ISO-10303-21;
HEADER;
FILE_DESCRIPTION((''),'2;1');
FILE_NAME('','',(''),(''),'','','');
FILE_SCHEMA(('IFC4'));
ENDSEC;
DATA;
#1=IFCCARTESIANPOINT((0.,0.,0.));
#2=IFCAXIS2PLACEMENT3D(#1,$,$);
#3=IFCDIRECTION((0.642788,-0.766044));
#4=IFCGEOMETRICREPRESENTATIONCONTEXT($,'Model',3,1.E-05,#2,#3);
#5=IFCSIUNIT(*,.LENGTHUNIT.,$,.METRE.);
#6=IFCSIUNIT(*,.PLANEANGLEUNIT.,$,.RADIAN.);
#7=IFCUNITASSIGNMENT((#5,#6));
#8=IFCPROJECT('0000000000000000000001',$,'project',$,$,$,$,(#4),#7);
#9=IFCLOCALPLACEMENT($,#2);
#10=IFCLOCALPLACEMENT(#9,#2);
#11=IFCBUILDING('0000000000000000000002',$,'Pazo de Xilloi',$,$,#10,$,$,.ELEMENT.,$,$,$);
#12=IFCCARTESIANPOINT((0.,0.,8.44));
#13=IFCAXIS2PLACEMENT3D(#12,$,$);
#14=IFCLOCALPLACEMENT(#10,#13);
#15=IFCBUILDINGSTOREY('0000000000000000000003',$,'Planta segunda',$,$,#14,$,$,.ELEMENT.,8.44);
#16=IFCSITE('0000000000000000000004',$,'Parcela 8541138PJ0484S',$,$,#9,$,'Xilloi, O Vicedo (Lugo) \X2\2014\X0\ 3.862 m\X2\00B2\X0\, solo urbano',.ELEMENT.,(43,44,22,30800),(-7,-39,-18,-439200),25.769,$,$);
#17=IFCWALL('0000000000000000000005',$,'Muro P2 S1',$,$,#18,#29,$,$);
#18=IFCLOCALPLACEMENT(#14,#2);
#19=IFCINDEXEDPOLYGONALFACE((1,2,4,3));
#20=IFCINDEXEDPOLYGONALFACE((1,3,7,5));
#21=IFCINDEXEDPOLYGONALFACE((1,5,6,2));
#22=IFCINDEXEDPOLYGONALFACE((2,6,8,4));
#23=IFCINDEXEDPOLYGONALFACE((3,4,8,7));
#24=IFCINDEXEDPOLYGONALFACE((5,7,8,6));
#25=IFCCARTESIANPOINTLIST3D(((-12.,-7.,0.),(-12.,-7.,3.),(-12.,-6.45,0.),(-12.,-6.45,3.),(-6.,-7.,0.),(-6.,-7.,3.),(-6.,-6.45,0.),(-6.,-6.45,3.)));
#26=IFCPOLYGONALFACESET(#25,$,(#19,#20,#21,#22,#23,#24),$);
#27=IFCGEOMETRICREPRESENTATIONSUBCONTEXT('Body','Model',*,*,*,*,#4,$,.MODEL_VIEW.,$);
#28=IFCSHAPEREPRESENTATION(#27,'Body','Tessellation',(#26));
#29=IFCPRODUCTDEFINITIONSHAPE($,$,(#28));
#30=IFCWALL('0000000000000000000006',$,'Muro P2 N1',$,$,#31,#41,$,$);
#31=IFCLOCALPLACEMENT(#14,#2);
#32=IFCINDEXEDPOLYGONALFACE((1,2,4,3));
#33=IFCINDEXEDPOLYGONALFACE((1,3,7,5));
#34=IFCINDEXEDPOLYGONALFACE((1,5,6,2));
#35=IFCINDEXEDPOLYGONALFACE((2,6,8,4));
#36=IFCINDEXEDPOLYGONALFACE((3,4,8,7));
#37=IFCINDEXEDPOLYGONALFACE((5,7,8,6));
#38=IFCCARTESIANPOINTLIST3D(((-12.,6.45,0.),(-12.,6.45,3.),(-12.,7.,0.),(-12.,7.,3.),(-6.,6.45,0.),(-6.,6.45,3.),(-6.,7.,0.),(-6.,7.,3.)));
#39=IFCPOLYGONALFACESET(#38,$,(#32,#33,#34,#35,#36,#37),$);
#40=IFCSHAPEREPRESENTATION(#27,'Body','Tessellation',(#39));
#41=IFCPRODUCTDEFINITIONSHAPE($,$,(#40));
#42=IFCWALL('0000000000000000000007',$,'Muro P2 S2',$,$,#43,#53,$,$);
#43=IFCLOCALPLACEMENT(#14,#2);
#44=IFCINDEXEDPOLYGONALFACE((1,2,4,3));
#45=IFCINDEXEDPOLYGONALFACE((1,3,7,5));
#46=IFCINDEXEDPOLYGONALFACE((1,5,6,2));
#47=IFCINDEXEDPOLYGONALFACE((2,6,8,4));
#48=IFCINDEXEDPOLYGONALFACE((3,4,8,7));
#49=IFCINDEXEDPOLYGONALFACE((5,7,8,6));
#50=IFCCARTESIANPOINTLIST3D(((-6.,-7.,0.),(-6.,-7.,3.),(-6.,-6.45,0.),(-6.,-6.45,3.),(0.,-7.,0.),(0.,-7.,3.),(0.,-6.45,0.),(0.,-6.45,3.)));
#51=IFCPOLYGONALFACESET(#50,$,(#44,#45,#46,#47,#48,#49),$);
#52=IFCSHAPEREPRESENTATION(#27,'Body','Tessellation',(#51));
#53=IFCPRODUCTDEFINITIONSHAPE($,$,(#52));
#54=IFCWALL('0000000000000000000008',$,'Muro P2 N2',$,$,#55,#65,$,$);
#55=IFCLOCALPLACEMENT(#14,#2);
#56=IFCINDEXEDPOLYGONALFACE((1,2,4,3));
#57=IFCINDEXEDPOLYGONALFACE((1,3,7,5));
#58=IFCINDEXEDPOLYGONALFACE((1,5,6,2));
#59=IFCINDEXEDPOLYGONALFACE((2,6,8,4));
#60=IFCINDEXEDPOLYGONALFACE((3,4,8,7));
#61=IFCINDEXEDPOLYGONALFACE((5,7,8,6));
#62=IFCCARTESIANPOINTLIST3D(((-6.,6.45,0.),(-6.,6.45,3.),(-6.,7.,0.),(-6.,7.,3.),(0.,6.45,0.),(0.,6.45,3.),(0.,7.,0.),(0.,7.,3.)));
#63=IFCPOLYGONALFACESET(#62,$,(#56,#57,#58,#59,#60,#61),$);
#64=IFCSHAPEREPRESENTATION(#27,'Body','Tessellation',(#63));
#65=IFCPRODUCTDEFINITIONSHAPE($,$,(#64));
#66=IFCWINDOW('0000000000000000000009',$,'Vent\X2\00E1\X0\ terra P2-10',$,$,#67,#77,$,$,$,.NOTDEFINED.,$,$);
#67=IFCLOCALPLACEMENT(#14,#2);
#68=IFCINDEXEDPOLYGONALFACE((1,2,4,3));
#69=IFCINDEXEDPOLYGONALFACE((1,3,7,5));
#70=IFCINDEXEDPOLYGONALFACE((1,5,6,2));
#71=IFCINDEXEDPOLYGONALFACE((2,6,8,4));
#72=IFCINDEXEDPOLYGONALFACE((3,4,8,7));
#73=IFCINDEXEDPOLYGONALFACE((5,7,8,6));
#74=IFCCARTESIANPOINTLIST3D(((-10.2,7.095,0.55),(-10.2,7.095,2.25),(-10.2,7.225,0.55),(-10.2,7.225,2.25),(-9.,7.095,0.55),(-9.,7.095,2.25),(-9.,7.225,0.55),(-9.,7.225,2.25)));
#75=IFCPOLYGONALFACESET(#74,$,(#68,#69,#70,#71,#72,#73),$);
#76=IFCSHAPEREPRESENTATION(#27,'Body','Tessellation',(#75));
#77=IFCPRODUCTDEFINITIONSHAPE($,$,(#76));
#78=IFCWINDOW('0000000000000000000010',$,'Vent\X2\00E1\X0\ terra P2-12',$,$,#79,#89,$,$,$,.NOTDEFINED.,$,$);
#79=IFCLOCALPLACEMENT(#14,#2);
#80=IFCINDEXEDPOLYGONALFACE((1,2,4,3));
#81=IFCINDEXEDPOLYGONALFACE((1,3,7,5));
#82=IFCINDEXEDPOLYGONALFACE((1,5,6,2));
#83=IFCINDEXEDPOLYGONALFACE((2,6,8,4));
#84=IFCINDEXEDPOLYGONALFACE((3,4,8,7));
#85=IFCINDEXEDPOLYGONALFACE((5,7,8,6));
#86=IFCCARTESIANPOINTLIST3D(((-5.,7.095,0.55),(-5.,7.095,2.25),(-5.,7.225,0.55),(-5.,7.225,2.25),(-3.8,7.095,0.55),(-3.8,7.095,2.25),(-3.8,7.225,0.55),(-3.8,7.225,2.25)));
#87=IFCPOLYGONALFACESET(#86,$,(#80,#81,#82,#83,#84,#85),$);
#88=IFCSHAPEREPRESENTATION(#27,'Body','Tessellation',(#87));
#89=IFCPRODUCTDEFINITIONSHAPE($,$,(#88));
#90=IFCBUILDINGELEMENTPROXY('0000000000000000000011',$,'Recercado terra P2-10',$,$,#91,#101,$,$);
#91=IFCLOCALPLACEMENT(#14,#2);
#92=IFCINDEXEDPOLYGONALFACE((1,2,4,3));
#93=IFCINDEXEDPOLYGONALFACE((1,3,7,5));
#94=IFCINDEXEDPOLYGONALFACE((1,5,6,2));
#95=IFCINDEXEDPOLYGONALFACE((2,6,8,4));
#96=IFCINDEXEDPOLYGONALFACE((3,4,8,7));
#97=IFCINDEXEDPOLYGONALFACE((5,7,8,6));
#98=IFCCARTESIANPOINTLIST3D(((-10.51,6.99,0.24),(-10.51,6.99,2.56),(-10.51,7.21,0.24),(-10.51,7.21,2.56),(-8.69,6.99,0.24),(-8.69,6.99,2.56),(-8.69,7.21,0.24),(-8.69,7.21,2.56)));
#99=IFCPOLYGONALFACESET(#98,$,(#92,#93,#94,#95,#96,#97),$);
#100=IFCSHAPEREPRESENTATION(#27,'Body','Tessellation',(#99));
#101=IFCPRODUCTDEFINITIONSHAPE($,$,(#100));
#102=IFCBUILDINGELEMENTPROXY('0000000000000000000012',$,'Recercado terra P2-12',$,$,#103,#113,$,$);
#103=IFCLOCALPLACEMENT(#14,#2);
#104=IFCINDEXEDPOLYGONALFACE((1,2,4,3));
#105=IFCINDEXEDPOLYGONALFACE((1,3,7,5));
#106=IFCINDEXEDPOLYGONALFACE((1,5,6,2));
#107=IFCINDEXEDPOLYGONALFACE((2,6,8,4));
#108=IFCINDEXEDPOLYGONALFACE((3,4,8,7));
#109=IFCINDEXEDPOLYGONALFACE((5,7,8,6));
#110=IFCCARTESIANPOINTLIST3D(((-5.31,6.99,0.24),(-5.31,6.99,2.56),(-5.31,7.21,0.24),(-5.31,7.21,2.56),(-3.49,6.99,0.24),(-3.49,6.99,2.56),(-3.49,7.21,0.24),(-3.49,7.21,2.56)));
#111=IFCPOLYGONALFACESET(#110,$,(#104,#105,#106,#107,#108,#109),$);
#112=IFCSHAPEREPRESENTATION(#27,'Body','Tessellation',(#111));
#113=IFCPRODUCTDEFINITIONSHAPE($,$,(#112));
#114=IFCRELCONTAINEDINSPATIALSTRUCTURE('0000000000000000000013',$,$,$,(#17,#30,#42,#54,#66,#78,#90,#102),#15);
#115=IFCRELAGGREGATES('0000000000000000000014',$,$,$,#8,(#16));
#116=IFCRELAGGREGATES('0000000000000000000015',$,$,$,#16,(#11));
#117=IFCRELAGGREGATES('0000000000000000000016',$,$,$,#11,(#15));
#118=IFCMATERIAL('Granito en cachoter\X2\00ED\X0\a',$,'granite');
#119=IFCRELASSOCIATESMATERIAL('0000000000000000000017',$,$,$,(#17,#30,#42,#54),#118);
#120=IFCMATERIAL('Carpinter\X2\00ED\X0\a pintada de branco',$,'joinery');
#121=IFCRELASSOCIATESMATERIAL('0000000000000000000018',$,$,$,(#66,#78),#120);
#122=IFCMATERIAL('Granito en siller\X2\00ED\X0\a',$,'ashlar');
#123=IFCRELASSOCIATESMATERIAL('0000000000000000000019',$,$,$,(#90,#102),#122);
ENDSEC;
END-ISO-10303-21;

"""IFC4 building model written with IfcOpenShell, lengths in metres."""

from ifc_helpers import new_model, si_unit, direction, frame, origin, origin_2d, place, context, subcontext, project, spatial, rectangle, extrude, material, element, save


model = new_model("IFC4")

# Units and contexts
model_context = context("Model", 3, precision=1e-05, world=origin(), true_north=direction((0.642788, -0.766044)))
body_context = subcontext(model_context, "Body", "Model", "MODEL_VIEW")
ifc_project = project(units=[si_unit("LENGTHUNIT", "METRE"), si_unit("PLANEANGLEUNIT", "RADIAN")], contexts=[model_context])

# Site, building, storey
site_placement = place(None, origin())
site = spatial("IfcSite", under=ifc_project, at=site_placement, Name="Parcela 8541138PJ0484S", LongName="Xilloi, O Vicedo (Lugo) — 3.862 m², solo urbano", CompositionType="ELEMENT", RefLatitude=(43, 44, 22, 30800), RefLongitude=(-7, -39, -18, -439200), RefElevation=25.769)
building_placement = place(site_placement, origin())
building = spatial("IfcBuilding", under=site, at=building_placement, Name="Pazo de Xilloi", CompositionType="ELEMENT")
storey_placement = place(building_placement, frame((0.0, 0.0, 8.44)))
storey = spatial("IfcBuildingStorey", under=building, at=storey_placement, Name="Planta segunda", CompositionType="ELEMENT", Elevation=8.44)

# Shared definitions
ifc_material_1 = material(Name="Carpintería pintada de branco", Category="joinery")

# Walls
ifc_material_2 = material(Name="Granito en cachotería", Category="granite")
for number, where, name in (
    (1, (-9.0, -6.725, 1.5), "Muro P2 S1"),
    (2, (-9.0, 6.725, 1.5), "Muro P2 N1"),
    (3, (-3.0, -6.725, 1.5), "Muro P2 S2"),
    (4, (-3.0, 6.725, 1.5), "Muro P2 N2"),
):
    element("IfcWall", number, at=place(storey_placement, frame(where)), inside=storey, material=ifc_material_2, Name=name, context=body_context, shape_type="SweptSolid", body=[
        extrude(rectangle(XDim=6.0, YDim=0.55, at=origin_2d()), frame((0.0, 0.0, -1.5)), (0.0, 0.0, 1.0), 3.0),
    ])

# Windows
for number, where, name in (
    (5, (-9.6, 7.16, 1.4), "Ventá terra P2-10"),
    (6, (-4.4, 7.16, 1.4), "Ventá terra P2-12"),
):
    element("IfcWindow", number, at=place(storey_placement, frame(where)), inside=storey, material=ifc_material_1, Name=name, PredefinedType="NOTDEFINED", context=body_context, shape_type="SweptSolid", body=[
        extrude(rectangle(XDim=1.2, YDim=0.13, at=origin_2d()), frame((0.0, 0.0, -0.85)), (0.0, 0.0, 1.0), 1.7),
    ])

# Building element proxies
ifc_material_3 = material(Name="Granito en sillería", Category="ashlar")
for number, where, name in (
    (7, (-9.6, 7.1, 1.4), "Recercado terra P2-10"),
    (8, (-4.4, 7.1, 1.4), "Recercado terra P2-12"),
):
    element("IfcBuildingElementProxy", number, at=place(storey_placement, frame(where)), inside=storey, material=ifc_material_3, Name=name, context=body_context, shape_type="SweptSolid", body=[
        extrude(rectangle(XDim=1.82, YDim=0.22, at=origin_2d()), frame((0.0, 0.0, -1.16)), (0.0, 0.0, 1.0), 2.32),
    ])

save(model, "model.ifc")
